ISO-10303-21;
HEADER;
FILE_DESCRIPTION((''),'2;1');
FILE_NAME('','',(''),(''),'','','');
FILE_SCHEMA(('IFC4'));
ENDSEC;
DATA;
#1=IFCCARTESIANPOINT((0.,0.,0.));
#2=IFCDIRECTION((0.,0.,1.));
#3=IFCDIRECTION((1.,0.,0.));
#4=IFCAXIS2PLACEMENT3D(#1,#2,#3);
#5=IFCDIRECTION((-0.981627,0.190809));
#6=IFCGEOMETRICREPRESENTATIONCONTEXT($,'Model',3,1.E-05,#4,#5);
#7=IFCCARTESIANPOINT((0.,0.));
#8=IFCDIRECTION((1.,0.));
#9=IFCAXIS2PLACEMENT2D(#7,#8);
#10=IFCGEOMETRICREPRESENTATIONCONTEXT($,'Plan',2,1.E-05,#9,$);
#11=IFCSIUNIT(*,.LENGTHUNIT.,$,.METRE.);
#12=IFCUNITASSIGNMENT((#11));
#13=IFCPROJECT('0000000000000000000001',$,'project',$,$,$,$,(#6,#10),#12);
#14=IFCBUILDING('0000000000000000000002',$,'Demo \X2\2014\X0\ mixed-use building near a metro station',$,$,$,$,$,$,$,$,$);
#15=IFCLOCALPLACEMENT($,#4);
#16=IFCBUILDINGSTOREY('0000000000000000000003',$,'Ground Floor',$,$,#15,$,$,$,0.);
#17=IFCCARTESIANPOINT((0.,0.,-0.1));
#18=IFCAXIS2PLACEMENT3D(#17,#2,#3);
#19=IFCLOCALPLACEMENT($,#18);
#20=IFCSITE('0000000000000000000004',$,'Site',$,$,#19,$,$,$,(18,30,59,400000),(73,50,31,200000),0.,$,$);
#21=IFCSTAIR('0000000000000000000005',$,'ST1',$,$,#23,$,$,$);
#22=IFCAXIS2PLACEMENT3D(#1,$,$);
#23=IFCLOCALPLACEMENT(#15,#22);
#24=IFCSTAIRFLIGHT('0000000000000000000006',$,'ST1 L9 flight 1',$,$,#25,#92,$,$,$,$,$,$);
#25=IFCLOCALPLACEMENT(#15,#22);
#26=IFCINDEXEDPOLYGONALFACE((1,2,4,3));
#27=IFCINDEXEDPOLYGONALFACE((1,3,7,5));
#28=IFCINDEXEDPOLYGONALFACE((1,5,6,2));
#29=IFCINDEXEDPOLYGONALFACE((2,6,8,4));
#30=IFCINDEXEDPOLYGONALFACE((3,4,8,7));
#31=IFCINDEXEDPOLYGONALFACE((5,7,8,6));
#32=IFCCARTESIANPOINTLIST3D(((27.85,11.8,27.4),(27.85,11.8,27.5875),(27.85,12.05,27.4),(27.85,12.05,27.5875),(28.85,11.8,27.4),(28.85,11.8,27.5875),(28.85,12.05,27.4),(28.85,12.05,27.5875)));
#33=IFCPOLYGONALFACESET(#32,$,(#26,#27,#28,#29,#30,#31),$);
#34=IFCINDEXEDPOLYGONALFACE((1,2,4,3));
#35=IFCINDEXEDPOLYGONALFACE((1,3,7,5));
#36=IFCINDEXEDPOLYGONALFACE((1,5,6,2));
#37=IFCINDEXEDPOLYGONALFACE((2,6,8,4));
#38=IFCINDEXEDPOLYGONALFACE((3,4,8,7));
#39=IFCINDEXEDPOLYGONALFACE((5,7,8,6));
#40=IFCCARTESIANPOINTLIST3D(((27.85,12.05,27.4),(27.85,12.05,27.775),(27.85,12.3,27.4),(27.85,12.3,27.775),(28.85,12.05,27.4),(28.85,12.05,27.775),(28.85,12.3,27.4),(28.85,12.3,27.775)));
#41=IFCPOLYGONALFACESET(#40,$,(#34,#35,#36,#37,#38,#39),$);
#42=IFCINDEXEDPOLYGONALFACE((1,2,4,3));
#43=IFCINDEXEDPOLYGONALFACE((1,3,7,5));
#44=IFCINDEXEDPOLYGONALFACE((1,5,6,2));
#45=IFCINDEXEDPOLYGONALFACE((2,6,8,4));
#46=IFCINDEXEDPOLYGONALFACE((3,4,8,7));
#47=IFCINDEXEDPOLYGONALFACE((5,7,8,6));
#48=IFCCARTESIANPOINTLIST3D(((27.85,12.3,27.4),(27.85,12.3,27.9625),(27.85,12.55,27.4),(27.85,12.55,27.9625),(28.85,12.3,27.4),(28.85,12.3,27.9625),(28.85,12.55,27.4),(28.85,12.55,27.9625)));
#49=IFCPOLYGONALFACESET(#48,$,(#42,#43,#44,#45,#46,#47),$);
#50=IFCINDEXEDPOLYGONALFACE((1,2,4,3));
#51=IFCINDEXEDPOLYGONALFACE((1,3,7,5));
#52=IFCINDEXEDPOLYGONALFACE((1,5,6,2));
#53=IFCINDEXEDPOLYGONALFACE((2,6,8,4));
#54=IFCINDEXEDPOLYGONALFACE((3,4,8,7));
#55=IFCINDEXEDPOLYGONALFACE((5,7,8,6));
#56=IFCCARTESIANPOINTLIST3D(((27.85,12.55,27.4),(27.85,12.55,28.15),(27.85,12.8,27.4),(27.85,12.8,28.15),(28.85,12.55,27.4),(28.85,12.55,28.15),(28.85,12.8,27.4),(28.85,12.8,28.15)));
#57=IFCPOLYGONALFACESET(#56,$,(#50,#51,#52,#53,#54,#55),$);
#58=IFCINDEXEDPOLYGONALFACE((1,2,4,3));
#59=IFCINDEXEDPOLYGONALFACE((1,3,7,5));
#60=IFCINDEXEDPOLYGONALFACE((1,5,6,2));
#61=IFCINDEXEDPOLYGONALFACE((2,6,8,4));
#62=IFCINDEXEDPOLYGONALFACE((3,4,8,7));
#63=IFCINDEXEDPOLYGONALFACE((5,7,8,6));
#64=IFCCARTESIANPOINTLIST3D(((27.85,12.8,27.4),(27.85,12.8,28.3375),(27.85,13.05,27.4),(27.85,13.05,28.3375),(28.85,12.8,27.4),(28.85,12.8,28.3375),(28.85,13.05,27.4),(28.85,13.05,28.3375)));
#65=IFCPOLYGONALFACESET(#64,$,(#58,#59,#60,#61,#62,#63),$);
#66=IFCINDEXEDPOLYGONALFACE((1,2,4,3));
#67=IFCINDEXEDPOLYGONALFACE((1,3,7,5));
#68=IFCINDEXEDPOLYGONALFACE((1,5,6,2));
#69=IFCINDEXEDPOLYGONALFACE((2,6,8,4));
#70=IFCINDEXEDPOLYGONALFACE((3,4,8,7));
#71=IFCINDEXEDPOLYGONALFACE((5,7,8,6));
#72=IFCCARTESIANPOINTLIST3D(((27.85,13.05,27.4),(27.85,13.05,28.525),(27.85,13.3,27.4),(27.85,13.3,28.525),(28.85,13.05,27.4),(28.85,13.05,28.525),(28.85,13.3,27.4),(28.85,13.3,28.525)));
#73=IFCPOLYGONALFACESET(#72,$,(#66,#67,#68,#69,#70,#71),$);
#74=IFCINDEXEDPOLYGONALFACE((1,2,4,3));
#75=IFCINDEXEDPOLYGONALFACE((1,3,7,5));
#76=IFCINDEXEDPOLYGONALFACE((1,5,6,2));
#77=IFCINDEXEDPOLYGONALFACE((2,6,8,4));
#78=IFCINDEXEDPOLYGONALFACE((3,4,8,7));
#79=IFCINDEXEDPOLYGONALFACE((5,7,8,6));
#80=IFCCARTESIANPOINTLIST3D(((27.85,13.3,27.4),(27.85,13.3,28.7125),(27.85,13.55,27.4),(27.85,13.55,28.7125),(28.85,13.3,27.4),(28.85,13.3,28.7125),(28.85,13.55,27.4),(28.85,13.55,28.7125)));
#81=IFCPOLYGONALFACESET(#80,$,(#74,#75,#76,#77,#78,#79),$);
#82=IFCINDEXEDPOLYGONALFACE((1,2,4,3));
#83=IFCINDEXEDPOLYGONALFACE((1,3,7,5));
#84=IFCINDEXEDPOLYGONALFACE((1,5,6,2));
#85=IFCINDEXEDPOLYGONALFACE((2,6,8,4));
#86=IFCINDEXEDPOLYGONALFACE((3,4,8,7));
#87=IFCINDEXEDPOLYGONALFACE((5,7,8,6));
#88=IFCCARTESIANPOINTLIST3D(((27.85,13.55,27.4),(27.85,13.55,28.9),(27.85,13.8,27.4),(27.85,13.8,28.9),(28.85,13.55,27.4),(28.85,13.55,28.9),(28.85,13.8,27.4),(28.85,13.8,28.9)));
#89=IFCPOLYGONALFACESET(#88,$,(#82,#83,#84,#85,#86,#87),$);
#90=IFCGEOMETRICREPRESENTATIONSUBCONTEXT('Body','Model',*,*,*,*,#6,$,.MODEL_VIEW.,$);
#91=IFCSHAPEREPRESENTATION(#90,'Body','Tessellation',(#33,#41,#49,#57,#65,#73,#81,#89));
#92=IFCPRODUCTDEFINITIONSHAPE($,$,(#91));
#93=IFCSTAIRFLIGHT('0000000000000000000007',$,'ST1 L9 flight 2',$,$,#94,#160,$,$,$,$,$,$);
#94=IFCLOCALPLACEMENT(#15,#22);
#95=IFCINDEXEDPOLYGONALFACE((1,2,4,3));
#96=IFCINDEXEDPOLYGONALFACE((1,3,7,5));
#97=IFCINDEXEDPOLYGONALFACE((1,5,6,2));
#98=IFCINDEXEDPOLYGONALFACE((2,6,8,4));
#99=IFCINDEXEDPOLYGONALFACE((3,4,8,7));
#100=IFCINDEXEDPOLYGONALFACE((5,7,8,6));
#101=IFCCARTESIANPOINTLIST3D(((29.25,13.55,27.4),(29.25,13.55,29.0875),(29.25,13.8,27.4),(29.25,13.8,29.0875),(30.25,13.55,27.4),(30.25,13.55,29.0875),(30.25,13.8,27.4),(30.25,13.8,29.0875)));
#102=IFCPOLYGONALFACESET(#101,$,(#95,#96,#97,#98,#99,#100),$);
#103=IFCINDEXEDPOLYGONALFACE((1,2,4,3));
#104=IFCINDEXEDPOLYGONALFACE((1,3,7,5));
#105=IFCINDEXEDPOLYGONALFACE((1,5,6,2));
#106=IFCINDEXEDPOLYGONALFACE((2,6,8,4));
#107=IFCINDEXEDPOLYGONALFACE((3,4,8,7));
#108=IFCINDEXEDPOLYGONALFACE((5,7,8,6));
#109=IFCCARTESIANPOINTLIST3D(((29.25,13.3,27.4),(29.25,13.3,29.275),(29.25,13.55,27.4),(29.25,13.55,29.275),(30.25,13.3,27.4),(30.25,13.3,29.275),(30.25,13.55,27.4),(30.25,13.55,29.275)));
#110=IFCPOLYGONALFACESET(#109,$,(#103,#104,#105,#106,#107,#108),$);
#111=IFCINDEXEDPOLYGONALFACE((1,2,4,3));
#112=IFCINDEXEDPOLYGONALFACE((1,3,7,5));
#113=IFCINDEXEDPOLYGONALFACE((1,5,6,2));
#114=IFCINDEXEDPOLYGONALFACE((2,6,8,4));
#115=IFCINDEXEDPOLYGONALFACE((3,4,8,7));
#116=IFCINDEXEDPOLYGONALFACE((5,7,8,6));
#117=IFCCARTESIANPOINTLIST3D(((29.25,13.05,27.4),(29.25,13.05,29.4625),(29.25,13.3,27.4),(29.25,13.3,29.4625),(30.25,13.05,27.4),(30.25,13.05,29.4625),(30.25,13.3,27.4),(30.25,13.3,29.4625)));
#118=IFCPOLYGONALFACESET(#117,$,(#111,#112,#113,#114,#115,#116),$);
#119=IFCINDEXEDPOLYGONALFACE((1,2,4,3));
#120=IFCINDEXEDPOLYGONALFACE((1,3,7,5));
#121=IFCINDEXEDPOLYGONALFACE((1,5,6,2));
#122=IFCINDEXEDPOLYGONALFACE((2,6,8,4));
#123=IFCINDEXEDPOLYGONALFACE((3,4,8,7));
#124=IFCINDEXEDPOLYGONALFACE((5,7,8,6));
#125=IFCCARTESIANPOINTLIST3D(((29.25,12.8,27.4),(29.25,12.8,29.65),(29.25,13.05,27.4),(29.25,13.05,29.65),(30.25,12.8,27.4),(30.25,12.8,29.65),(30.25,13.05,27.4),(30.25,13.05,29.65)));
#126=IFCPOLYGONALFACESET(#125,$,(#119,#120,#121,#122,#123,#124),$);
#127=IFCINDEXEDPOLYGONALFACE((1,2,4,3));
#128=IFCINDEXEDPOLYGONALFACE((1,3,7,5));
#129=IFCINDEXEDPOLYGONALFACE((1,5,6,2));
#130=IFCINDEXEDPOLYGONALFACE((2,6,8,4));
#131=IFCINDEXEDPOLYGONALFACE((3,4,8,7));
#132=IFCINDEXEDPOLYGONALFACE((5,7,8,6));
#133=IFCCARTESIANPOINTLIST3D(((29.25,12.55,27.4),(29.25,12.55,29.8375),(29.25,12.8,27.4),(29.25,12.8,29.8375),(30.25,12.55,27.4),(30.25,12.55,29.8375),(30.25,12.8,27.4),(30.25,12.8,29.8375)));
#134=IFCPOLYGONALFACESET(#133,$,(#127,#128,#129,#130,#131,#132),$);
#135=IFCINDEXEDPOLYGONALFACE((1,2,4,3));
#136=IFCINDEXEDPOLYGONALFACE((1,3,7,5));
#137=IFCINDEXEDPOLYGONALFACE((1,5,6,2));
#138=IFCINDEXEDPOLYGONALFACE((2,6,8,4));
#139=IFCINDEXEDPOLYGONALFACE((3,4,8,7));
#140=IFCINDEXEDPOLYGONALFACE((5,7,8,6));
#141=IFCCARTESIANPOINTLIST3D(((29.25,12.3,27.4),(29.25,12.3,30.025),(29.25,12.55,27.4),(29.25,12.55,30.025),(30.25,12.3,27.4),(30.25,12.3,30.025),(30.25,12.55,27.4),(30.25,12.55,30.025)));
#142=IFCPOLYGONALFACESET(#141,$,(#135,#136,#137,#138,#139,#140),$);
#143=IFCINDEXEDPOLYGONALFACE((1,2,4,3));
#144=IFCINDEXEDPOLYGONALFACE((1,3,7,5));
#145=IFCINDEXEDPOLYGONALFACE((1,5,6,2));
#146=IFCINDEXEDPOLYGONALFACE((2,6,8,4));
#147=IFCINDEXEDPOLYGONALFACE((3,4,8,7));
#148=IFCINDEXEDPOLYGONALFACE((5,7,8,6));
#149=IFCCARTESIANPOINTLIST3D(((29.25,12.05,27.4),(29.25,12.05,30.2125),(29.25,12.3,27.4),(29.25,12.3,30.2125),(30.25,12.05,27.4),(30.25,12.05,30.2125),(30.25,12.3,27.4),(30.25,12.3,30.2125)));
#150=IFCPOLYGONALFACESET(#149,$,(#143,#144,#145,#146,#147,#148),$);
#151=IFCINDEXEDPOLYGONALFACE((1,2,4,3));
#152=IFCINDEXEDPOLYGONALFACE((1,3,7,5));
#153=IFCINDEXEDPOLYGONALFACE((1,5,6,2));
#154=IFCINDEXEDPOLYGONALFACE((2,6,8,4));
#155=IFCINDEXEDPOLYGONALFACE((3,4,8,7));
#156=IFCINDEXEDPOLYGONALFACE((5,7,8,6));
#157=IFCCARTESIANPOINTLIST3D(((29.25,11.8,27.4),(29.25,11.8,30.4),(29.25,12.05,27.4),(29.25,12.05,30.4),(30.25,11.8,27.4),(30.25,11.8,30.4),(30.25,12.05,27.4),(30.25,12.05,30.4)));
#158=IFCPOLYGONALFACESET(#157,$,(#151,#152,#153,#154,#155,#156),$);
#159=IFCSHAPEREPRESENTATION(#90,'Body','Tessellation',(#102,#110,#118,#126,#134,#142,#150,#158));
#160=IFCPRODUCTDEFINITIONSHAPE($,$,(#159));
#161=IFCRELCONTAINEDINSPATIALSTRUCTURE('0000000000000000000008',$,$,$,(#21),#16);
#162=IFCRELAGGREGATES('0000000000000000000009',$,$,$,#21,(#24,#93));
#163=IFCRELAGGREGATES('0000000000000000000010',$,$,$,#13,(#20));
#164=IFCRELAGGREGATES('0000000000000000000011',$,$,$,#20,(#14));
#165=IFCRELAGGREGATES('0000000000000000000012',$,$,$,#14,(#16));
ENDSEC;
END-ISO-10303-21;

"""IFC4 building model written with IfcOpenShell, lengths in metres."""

from ifc_helpers import new_model, si_unit, direction, frame, origin_with_axes, origin_2d_with_axis, place, context, subcontext, project, spatial, line, indexed_curve, outline, extrude, element, aggregate, save


model = new_model("IFC4")

# Units and contexts
model_context = context("Model", 3, precision=1e-05, world=origin_with_axes(), true_north=direction((-0.981627, 0.190809)))
plan_context = context("Plan", 2, precision=1e-05, world=origin_2d_with_axis())
body_context = subcontext(model_context, "Body", "Model", "MODEL_VIEW")
ifc_project = project(units=[si_unit("LENGTHUNIT", "METRE")], contexts=[model_context, plan_context])

# Site, building, storey
site_placement = place(None, frame((0.0, 0.0, -0.1), z_axis=(0.0, 0.0, 1.0), x_axis=(1.0, 0.0, 0.0)))
site = spatial("IfcSite", under=ifc_project, at=site_placement, Name="Site", RefLatitude=(18, 30, 59, 400000), RefLongitude=(73, 50, 31, 200000), RefElevation=0.0)
building = spatial("IfcBuilding", under=site, Name="Demo — mixed-use building near a metro station")
storey_placement = place(None, origin_with_axes())
storey = spatial("IfcBuildingStorey", under=building, at=storey_placement, Name="Ground Floor", Elevation=0.0)

# Stair, stair flights
stair = element("IfcStair", 1, inside=storey, Name="ST1")
stair_flight_1_placement = place(None, origin_with_axes())
stair_flight_1 = element("IfcStairFlight", 2, at=stair_flight_1_placement, Name="ST1 L9 flight 1", context=body_context, shape_type="SweptSolid", body=[
    extrude(outline(indexed_curve([(27.85, 11.8), (28.85, 11.8), (28.85, 12.05), (27.85, 12.05)], segments=[line(1, 2, 3, 4, 1)])), frame((0.0, 0.0, 27.4), z_axis=(0.0, 0.0, 1.0), x_axis=(1.0, 0.0, 0.0)), (0.0, 0.0, 1.0), 0.1875),
    extrude(outline(indexed_curve([(27.85, 12.05), (28.85, 12.05), (28.85, 12.3), (27.85, 12.3)], segments=[line(1, 2, 3, 4, 1)])), frame((0.0, 0.0, 27.4), z_axis=(0.0, 0.0, 1.0), x_axis=(1.0, 0.0, 0.0)), (0.0, 0.0, 1.0), 0.375),
    extrude(outline(indexed_curve([(27.85, 12.3), (28.85, 12.3), (28.85, 12.55), (27.85, 12.55)], segments=[line(1, 2, 3, 4, 1)])), frame((0.0, 0.0, 27.4), z_axis=(0.0, 0.0, 1.0), x_axis=(1.0, 0.0, 0.0)), (0.0, 0.0, 1.0), 0.5625),
    extrude(outline(indexed_curve([(27.85, 12.55), (28.85, 12.55), (28.85, 12.8), (27.85, 12.8)], segments=[line(1, 2, 3, 4, 1)])), frame((0.0, 0.0, 27.4), z_axis=(0.0, 0.0, 1.0), x_axis=(1.0, 0.0, 0.0)), (0.0, 0.0, 1.0), 0.75),
    extrude(outline(indexed_curve([(27.85, 12.8), (28.85, 12.8), (28.85, 13.05), (27.85, 13.05)], segments=[line(1, 2, 3, 4, 1)])), frame((0.0, 0.0, 27.4), z_axis=(0.0, 0.0, 1.0), x_axis=(1.0, 0.0, 0.0)), (0.0, 0.0, 1.0), 0.9375),
    extrude(outline(indexed_curve([(27.85, 13.05), (28.85, 13.05), (28.85, 13.3), (27.85, 13.3)], segments=[line(1, 2, 3, 4, 1)])), frame((0.0, 0.0, 27.4), z_axis=(0.0, 0.0, 1.0), x_axis=(1.0, 0.0, 0.0)), (0.0, 0.0, 1.0), 1.125),
    extrude(outline(indexed_curve([(27.85, 13.3), (28.85, 13.3), (28.85, 13.55), (27.85, 13.55)], segments=[line(1, 2, 3, 4, 1)])), frame((0.0, 0.0, 27.4), z_axis=(0.0, 0.0, 1.0), x_axis=(1.0, 0.0, 0.0)), (0.0, 0.0, 1.0), 1.3125),
    extrude(outline(indexed_curve([(27.85, 13.55), (28.85, 13.55), (28.85, 13.8), (27.85, 13.8)], segments=[line(1, 2, 3, 4, 1)])), frame((0.0, 0.0, 27.4), z_axis=(0.0, 0.0, 1.0), x_axis=(1.0, 0.0, 0.0)), (0.0, 0.0, 1.0), 1.5),
])
stair_flight_2_placement = place(None, origin_with_axes())
stair_flight_2 = element("IfcStairFlight", 3, at=stair_flight_2_placement, Name="ST1 L9 flight 2", context=body_context, shape_type="SweptSolid", body=[
    extrude(outline(indexed_curve([(29.25, 13.55), (30.25, 13.55), (30.25, 13.8), (29.25, 13.8)], segments=[line(1, 2, 3, 4, 1)])), frame((0.0, 0.0, 27.4), z_axis=(0.0, 0.0, 1.0), x_axis=(1.0, 0.0, 0.0)), (0.0, 0.0, 1.0), 1.6875),
    extrude(outline(indexed_curve([(29.25, 13.3), (30.25, 13.3), (30.25, 13.55), (29.25, 13.55)], segments=[line(1, 2, 3, 4, 1)])), frame((0.0, 0.0, 27.4), z_axis=(0.0, 0.0, 1.0), x_axis=(1.0, 0.0, 0.0)), (0.0, 0.0, 1.0), 1.875),
    extrude(outline(indexed_curve([(29.25, 13.05), (30.25, 13.05), (30.25, 13.3), (29.25, 13.3)], segments=[line(1, 2, 3, 4, 1)])), frame((0.0, 0.0, 27.4), z_axis=(0.0, 0.0, 1.0), x_axis=(1.0, 0.0, 0.0)), (0.0, 0.0, 1.0), 2.0625),
    extrude(outline(indexed_curve([(29.25, 12.8), (30.25, 12.8), (30.25, 13.05), (29.25, 13.05)], segments=[line(1, 2, 3, 4, 1)])), frame((0.0, 0.0, 27.4), z_axis=(0.0, 0.0, 1.0), x_axis=(1.0, 0.0, 0.0)), (0.0, 0.0, 1.0), 2.25),
    extrude(outline(indexed_curve([(29.25, 12.55), (30.25, 12.55), (30.25, 12.8), (29.25, 12.8)], segments=[line(1, 2, 3, 4, 1)])), frame((0.0, 0.0, 27.4), z_axis=(0.0, 0.0, 1.0), x_axis=(1.0, 0.0, 0.0)), (0.0, 0.0, 1.0), 2.4375),
    extrude(outline(indexed_curve([(29.25, 12.3), (30.25, 12.3), (30.25, 12.55), (29.25, 12.55)], segments=[line(1, 2, 3, 4, 1)])), frame((0.0, 0.0, 27.4), z_axis=(0.0, 0.0, 1.0), x_axis=(1.0, 0.0, 0.0)), (0.0, 0.0, 1.0), 2.625),
    extrude(outline(indexed_curve([(29.25, 12.05), (30.25, 12.05), (30.25, 12.3), (29.25, 12.3)], segments=[line(1, 2, 3, 4, 1)])), frame((0.0, 0.0, 27.4), z_axis=(0.0, 0.0, 1.0), x_axis=(1.0, 0.0, 0.0)), (0.0, 0.0, 1.0), 2.8125),
    extrude(outline(indexed_curve([(29.25, 11.8), (30.25, 11.8), (30.25, 12.05), (29.25, 12.05)], segments=[line(1, 2, 3, 4, 1)])), frame((0.0, 0.0, 27.4), z_axis=(0.0, 0.0, 1.0), x_axis=(1.0, 0.0, 0.0)), (0.0, 0.0, 1.0), 3.0),
])
aggregate(stair, [stair_flight_1, stair_flight_2])

save(model, "model.ifc")
